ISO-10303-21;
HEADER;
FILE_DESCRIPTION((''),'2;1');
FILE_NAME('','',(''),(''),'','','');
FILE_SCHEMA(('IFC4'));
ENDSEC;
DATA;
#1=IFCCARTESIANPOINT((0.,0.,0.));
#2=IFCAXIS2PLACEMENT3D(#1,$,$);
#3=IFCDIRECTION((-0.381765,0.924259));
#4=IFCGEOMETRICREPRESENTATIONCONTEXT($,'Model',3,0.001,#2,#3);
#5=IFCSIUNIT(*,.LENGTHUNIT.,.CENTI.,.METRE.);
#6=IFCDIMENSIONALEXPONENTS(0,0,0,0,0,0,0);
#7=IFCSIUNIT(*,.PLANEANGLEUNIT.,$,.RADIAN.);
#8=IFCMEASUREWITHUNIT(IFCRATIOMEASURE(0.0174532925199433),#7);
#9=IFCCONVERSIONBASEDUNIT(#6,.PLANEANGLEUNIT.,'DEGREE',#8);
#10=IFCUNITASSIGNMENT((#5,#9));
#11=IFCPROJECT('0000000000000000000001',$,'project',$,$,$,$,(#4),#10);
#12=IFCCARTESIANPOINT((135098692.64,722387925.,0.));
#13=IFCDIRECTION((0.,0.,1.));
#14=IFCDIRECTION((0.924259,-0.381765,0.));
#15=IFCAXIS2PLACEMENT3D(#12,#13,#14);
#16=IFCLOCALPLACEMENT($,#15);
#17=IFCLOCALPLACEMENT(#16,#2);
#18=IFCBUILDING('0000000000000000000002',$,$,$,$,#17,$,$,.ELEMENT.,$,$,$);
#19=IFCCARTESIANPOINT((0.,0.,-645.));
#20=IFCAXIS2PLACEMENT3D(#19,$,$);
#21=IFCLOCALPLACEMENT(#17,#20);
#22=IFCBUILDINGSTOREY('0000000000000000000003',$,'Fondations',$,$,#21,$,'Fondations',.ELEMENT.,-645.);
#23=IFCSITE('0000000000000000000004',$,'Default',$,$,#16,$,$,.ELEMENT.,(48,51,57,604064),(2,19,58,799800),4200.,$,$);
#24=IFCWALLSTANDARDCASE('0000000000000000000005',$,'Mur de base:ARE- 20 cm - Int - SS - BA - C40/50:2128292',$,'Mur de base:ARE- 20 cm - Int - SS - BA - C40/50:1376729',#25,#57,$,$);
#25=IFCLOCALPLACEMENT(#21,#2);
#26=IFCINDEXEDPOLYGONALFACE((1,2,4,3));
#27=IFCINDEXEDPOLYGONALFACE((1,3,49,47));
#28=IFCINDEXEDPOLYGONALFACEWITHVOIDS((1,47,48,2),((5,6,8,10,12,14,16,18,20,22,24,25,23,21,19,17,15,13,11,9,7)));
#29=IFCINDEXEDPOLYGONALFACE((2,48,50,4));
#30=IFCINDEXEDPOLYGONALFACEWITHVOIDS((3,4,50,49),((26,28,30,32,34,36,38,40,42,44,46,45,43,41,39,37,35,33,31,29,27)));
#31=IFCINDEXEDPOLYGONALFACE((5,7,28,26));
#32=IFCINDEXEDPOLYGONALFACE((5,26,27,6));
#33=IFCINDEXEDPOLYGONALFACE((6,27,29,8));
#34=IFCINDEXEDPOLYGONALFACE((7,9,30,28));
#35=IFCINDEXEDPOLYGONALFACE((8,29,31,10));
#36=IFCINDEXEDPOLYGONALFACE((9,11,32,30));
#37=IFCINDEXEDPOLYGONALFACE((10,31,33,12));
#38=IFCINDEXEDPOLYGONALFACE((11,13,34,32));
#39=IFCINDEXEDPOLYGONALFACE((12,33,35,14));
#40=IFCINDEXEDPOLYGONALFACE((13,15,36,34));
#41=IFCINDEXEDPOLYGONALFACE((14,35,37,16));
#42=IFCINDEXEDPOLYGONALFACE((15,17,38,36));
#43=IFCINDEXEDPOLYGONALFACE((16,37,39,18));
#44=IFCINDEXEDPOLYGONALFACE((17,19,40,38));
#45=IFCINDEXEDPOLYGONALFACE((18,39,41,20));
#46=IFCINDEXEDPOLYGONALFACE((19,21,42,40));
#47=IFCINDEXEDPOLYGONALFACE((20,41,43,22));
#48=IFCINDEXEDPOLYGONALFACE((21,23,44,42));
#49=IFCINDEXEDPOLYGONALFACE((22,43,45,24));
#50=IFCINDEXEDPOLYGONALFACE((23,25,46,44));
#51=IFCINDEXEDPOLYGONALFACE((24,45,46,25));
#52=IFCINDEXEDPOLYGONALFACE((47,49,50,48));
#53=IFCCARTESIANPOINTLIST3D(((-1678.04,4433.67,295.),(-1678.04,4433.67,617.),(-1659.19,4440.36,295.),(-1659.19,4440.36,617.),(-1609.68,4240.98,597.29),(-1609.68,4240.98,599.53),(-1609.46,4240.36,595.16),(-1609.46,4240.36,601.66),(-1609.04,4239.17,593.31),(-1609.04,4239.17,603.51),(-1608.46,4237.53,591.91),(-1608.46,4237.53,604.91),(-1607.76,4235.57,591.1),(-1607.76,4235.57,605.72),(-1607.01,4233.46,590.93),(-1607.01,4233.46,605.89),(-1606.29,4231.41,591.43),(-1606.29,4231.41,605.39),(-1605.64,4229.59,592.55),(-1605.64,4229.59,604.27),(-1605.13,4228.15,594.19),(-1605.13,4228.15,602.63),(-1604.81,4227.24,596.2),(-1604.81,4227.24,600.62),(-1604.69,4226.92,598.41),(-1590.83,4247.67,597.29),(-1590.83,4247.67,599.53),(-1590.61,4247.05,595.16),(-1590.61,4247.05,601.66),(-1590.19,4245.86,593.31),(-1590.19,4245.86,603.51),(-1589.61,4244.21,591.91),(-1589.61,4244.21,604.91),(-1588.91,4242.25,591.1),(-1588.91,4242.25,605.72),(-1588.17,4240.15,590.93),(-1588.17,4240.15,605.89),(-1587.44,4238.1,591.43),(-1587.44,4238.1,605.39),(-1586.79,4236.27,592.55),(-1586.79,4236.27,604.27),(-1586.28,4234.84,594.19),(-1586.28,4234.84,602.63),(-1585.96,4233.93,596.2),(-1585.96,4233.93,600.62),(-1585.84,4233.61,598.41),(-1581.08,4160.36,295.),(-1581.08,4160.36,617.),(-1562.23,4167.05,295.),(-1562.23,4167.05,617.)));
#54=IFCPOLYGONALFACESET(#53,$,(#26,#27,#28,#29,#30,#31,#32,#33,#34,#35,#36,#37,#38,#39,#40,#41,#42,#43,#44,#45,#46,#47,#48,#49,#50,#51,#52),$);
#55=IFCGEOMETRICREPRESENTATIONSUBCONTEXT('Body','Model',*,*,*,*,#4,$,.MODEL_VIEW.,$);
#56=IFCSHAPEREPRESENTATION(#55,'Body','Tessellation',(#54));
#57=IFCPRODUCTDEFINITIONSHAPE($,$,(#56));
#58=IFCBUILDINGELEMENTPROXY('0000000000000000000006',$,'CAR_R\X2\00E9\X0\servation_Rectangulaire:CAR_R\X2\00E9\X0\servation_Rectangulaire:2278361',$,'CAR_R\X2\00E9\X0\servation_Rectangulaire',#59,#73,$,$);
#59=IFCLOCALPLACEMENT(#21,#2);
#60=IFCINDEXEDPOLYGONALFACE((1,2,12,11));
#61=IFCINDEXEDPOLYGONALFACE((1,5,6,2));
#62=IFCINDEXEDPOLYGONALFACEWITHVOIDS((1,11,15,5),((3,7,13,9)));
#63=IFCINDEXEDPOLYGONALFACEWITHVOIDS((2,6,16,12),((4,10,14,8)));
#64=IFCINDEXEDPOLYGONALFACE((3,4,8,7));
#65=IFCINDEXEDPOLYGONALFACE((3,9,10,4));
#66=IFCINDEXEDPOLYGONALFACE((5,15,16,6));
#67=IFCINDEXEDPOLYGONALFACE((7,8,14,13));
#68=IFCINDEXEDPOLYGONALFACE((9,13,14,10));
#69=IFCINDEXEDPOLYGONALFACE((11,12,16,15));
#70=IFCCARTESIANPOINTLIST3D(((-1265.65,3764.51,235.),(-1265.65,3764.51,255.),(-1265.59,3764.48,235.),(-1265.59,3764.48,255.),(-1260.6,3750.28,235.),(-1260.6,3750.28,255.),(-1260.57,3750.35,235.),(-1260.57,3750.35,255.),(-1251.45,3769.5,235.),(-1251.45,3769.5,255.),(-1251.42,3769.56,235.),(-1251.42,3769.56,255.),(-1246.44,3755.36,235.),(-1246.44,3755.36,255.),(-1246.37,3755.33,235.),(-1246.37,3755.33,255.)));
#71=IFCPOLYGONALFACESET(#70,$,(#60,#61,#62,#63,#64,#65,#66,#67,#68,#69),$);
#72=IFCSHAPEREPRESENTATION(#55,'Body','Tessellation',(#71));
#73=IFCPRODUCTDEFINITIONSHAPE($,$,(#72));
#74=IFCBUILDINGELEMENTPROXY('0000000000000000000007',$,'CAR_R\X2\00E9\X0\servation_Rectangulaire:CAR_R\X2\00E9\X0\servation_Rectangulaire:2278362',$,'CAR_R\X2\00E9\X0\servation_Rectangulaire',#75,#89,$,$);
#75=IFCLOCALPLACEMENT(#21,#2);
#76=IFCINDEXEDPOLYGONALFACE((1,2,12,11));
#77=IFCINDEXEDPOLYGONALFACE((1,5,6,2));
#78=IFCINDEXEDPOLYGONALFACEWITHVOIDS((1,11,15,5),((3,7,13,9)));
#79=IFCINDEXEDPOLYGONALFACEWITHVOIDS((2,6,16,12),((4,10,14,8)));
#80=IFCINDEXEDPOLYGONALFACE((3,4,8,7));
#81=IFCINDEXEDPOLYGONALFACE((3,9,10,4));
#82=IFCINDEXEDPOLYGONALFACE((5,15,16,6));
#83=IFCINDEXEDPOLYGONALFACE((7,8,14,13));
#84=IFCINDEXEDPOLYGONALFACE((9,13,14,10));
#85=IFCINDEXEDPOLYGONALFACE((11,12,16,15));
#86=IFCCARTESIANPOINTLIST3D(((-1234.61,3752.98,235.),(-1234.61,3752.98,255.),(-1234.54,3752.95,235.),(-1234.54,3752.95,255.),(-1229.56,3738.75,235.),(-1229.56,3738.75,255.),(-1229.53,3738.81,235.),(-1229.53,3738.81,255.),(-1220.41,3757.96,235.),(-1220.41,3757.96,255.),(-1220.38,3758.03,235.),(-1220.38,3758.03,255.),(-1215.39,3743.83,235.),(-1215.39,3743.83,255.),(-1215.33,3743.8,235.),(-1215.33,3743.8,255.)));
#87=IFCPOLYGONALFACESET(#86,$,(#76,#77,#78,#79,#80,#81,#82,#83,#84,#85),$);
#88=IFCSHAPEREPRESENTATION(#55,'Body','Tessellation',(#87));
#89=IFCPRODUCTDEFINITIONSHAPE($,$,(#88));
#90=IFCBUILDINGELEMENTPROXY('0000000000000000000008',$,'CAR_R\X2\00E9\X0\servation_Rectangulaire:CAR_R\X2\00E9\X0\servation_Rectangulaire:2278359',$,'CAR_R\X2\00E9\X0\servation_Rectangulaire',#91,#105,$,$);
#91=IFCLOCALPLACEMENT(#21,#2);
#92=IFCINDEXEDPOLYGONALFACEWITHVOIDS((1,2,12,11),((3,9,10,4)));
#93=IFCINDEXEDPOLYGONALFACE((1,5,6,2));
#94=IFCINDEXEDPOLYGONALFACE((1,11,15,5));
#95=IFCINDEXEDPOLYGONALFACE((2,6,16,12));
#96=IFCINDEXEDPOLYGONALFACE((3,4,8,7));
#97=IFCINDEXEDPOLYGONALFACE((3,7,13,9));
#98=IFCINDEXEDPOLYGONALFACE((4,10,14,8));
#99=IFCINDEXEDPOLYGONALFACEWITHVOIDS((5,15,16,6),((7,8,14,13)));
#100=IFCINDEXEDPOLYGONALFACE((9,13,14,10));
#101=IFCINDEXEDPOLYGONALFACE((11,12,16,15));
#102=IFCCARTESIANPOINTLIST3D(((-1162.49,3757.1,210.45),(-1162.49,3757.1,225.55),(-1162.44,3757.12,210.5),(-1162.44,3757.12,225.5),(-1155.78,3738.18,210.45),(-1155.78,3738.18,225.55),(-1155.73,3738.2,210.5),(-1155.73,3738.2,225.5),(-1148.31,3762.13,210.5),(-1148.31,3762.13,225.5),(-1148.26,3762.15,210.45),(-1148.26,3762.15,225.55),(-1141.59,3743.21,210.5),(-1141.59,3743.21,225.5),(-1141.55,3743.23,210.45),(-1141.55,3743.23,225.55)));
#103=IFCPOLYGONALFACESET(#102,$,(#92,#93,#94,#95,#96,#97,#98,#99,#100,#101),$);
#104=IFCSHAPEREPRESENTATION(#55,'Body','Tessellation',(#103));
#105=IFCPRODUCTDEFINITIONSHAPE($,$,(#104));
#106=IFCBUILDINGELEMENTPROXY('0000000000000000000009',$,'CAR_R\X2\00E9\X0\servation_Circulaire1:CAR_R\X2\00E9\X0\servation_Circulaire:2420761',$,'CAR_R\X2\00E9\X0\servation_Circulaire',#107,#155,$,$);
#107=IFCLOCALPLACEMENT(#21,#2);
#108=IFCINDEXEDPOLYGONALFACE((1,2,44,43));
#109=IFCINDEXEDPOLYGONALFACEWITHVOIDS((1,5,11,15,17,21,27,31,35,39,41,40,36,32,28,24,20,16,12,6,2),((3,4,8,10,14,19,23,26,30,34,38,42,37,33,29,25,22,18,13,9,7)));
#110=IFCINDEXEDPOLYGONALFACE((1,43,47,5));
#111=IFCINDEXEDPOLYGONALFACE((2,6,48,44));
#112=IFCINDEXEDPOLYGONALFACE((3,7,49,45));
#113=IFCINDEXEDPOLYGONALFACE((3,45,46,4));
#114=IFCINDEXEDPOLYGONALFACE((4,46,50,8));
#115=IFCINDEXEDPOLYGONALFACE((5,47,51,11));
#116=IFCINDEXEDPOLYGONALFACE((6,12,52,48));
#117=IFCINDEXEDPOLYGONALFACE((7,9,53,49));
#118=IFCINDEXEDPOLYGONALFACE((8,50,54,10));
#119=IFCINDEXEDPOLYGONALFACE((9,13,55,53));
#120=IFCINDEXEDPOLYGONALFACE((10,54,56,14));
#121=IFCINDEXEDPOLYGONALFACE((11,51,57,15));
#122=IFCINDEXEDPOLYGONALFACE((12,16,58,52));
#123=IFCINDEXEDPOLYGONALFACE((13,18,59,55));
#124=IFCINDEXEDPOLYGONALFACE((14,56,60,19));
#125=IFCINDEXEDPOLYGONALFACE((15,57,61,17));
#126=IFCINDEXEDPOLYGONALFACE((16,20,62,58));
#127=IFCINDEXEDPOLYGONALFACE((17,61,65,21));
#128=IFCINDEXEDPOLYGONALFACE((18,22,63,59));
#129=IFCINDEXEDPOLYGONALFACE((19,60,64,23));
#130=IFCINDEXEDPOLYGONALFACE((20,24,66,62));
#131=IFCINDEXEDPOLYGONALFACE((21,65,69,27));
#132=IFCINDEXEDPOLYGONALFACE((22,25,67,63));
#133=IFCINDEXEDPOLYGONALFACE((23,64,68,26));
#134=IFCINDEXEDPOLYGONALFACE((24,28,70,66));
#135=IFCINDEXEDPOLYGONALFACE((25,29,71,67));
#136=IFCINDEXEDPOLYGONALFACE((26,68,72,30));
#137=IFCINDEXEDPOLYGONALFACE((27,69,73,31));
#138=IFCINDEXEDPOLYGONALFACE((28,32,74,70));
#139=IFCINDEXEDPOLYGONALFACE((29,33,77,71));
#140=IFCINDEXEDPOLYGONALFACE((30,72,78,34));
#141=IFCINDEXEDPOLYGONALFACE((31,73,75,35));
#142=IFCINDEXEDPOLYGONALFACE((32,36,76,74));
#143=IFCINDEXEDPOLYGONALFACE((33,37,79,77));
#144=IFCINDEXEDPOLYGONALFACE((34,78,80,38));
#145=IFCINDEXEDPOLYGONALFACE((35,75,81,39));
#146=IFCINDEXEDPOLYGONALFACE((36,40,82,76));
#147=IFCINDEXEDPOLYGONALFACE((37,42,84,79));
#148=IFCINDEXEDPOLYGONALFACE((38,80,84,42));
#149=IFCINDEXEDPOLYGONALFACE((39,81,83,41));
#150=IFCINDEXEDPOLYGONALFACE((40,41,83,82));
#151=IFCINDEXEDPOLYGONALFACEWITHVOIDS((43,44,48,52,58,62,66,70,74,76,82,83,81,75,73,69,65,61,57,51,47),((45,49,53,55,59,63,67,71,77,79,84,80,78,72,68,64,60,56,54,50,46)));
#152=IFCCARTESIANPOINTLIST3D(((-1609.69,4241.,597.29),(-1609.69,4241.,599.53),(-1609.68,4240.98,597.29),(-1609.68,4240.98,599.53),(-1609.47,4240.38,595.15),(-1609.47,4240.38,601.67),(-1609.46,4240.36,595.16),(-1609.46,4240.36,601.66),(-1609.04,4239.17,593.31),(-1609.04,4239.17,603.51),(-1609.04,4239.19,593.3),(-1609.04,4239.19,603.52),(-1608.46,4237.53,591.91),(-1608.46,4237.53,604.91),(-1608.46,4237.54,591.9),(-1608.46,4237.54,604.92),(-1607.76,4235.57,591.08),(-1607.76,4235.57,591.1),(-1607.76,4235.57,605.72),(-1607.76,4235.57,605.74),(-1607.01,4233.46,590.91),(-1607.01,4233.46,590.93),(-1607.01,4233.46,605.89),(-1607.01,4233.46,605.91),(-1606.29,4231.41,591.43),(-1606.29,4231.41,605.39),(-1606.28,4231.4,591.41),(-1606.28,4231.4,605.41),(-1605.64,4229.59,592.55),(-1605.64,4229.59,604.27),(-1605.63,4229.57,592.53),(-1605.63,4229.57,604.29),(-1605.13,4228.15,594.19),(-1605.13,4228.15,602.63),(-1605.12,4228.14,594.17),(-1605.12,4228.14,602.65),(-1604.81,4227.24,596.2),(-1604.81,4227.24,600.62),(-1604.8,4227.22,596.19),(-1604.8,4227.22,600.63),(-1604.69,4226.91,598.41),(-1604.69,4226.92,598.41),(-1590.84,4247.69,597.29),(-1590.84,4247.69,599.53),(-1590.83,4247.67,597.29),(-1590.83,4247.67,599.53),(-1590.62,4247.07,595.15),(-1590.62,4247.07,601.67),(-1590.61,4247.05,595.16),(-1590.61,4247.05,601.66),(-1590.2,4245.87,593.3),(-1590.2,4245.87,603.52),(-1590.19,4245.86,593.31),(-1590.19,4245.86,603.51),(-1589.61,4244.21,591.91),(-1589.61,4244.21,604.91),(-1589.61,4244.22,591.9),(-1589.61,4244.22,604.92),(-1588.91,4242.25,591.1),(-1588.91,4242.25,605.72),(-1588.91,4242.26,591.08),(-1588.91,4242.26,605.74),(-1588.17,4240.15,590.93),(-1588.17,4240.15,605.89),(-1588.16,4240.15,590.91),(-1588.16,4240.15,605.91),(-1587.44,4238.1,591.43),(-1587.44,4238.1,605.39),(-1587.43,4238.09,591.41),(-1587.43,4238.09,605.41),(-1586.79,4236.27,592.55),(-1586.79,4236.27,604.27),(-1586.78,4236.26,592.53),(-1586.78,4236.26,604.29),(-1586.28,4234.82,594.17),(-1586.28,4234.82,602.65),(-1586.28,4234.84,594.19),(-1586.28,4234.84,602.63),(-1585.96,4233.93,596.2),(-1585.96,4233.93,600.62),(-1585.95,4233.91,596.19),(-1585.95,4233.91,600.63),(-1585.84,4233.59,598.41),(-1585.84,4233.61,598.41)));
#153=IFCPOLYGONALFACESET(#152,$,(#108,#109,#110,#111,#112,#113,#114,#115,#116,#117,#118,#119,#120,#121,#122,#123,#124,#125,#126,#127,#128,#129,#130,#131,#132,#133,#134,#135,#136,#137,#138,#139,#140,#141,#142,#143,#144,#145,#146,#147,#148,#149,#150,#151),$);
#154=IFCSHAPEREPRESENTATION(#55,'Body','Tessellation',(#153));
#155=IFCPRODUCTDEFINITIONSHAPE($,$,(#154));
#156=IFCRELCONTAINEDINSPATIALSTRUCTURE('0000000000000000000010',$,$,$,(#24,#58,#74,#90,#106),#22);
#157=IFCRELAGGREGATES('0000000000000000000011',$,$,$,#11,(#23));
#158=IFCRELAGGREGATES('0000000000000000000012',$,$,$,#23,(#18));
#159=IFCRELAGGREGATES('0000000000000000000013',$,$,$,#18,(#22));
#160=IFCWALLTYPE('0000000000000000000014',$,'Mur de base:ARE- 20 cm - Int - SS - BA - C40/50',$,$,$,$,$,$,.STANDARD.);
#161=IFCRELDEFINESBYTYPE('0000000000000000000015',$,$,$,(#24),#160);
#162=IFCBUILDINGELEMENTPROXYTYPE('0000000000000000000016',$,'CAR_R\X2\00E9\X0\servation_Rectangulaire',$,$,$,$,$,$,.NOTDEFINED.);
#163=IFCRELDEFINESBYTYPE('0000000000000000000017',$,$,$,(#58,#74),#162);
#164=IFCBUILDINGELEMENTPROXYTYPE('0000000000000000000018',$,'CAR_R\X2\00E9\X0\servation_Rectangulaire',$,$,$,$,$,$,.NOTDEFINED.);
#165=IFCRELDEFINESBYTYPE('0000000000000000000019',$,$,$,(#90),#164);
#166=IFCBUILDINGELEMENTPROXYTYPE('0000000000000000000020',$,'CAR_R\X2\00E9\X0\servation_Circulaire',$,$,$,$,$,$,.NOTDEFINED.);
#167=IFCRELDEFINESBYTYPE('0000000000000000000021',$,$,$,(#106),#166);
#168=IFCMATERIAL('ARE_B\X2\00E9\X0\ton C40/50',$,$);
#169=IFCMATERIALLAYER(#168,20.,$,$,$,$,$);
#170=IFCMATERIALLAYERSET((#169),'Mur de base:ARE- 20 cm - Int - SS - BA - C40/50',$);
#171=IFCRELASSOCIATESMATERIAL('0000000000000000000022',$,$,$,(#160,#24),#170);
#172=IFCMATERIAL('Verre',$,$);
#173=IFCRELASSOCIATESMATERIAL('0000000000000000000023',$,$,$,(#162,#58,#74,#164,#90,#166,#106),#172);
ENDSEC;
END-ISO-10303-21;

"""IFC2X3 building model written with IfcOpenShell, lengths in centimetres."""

from ifc_helpers import new_model, entity, si_unit, converted_unit, direction, frame, frame_2d, origin, place, context, subcontext, project, spatial, polyline, rectangle, circle, hollow_circle, outline, extrude, clip, bounded_halfspace, source, transform, mapped, material, layer, layer_set, layer_usage, type_object, type_shapes, element, save


model = new_model("IFC2X3")

# Units and contexts
model_context = context("Model", 3, precision=0.001, world=origin(), true_north=direction((-0.381765, 0.924259)))
body_context = subcontext(model_context, "Body", "Model", "MODEL_VIEW")
ifc_project = project(units=[si_unit("LENGTHUNIT", "METRE", prefix="CENTI"), converted_unit("PLANEANGLEUNIT", "DEGREE", entity("IfcRatioMeasure", 0.0174532925199433), si_unit("PLANEANGLEUNIT", "RADIAN"), dimensions=[0, 0, 0, 0, 0, 0, 0])], contexts=[model_context])

# Site, building, storey
site_placement = place(None, frame((135098692.64, 722387925.0, 0.0), z_axis=(0.0, 0.0, 1.0), x_axis=(0.924259, -0.381765, 0.0)))
site = spatial("IfcSite", under=ifc_project, at=site_placement, Name="Default", CompositionType="ELEMENT", RefLatitude=(48, 51, 57, 604064), RefLongitude=(2, 19, 58, 799800), RefElevation=4200.0)
building_placement = place(site_placement, origin())
building = spatial("IfcBuilding", under=site, at=building_placement, CompositionType="ELEMENT")
storey_placement = place(building_placement, frame((0.0, 0.0, -645.0)))
storey = spatial("IfcBuildingStorey", under=building, at=storey_placement, Name="Fondations", LongName="Fondations", CompositionType="ELEMENT", Elevation=-645.0)

# Shared definitions
ifc_material_1 = material(Name="ARE_Béton C40/50")

# Shared definitions
ifc_layer_1 = layer(ifc_material_1, 20.0)
ifc_layer_set_1 = layer_set([ifc_layer_1], Name="Mur de base:ARE- 20 cm - Int - SS - BA - C40/50")
wall_type_1 = type_object("IfcWallType", Name="Mur de base:ARE- 20 cm - Int - SS - BA - C40/50", PredefinedType="STANDARD", material=ifc_layer_set_1)

# Wall, opening
ifc_layer_usage_1 = layer_usage(ifc_layer_set_1, "AXIS2", "NEGATIVE", 10.0)
wall_1_placement = place(storey_placement, frame((-1571.66, 4163.71, 295.0), z_axis=(0.0, 0.0, 1.0), x_axis=(-0.334351, 0.942449, 0.0)))
wall_1 = element("IfcWallStandardCase", 1, at=wall_1_placement, inside=storey, type_object=wall_type_1, material=ifc_layer_usage_1, Name="Mur de base:ARE- 20 cm - Int - SS - BA - C40/50:2128292", ObjectType="Mur de base:ARE- 20 cm - Int - SS - BA - C40/50:1376729", context=body_context, shape_type="Clipping", body=[
    clip(extrude(rectangle(XDim=290.0, YDim=20.0, at=frame_2d((145.0, 0.0), x_axis=(-1.0, 0.0))), origin(), (0.0, 0.0, 1.0), 322.0), bounded_halfspace(frame((0.0, -10.0, 322.0), z_axis=(0.0, 0.0, -1.0), x_axis=(0.23358, -0.972338, 0.0)), True, frame((0.0, -10.0, 322.0)), polyline([(0.0, 0.0), (290.0, 0.0), (290.0, 20.0), (265.99, 20.0), (20.0, 20.0), (0.0, 20.0), (0.0, 0.0)]))),
])
opening_1_placement = place(wall_1_placement, origin())
element("IfcOpeningElement", 2, at=opening_1_placement, cuts=wall_1, ObjectType="Opening", context=body_context, shape_type="SweptSolid", body=[
    extrude(circle(Radius=7.5, at=frame_2d((0.0, 0.0), x_axis=(1.0, 0.0))), frame((78.13, -10.0, 303.41), z_axis=(0.0, 1.0, 0.0), x_axis=(-1.0, 0.0, 0.0)), (0.0, 0.0, 1.0), 20.0),
])

# Building element proxies
ifc_material_2 = material(Name="Verre")
building_element_proxy_type_1 = type_object("IfcBuildingElementProxyType", Name="CAR_Réservation_Rectangulaire", PredefinedType="NOTDEFINED", material=ifc_material_2)
shared_shape_1 = source(origin(), body_context, "Body", "SweptSolid", [
    extrude(outline(polyline([(-7.55, -7.55), (7.55, -7.55), (7.55, 7.55), (-7.55, 7.55), (-7.55, -7.55)]), holes=[polyline([(7.5, -7.5), (-7.5, -7.5), (-7.5, 7.5), (7.5, 7.5), (7.5, -7.5)])]), frame((0.0, 0.0, -20.0), z_axis=(0.0, 0.0, 1.0), x_axis=(-1.0, 0.0, 0.0)), (0.0, 0.0, 1.0), 20.0),
])
type_shapes(building_element_proxy_type_1, [shared_shape_1])
for number, where, z_axis, x_axis, name in (
    (3, (-1256.01, 3759.92, 235.0), (0.0, 0.0, -1.0), (0.942456, 0.334331, 0.0), "CAR_Réservation_Rectangulaire:CAR_Réservation_Rectangulaire:2278361"),
    (4, (-1224.97, 3748.39, 235.0), (0.0, 0.0, -1.0), (0.942456, 0.334331, 0.0), "CAR_Réservation_Rectangulaire:CAR_Réservation_Rectangulaire:2278362"),
):
    element("IfcBuildingElementProxy", number, at=place(storey_placement, frame(where, z_axis=z_axis, x_axis=x_axis)), inside=storey, type_object=building_element_proxy_type_1, material=ifc_material_2, Name=name, ObjectType="CAR_Réservation_Rectangulaire", context=body_context, shape_type="MappedRepresentation", body=[
        mapped(shared_shape_1, transform((0.0, 0.0, 0.0), scale=1.0)),
    ])
building_element_proxy_type_2 = type_object("IfcBuildingElementProxyType", Name="CAR_Réservation_Rectangulaire", PredefinedType="NOTDEFINED", material=ifc_material_2)
shared_shape_2 = source(origin(), body_context, "Body", "SweptSolid", [
    extrude(outline(polyline([(-7.55, -7.55), (7.55, -7.55), (7.55, 7.55), (-7.55, 7.55), (-7.55, -7.55)]), holes=[polyline([(7.5, -7.5), (-7.5, -7.5), (-7.5, 7.5), (7.5, 7.5), (7.5, -7.5)])]), frame((0.0, 0.0, -20.08), z_axis=(0.0, 0.0, 1.0), x_axis=(-1.0, 0.0, 0.0)), (0.0, 0.0, 1.0), 20.08),
])
type_shapes(building_element_proxy_type_2, [shared_shape_2])
proxy_1_placement = place(storey_placement, frame((-1155.37, 3759.62, 218.0), z_axis=(-0.334351, 0.942449, 0.0), x_axis=(-0.942449, -0.334351, 0.0)))
element("IfcBuildingElementProxy", 5, at=proxy_1_placement, inside=storey, type_object=building_element_proxy_type_2, material=ifc_material_2, Name="CAR_Réservation_Rectangulaire:CAR_Réservation_Rectangulaire:2278359", ObjectType="CAR_Réservation_Rectangulaire", context=body_context, shape_type="MappedRepresentation", body=[
    mapped(shared_shape_2, transform((0.0, 0.0, 0.0), scale=1.0)),
])
building_element_proxy_type_3 = type_object("IfcBuildingElementProxyType", Name="CAR_Réservation_Circulaire", PredefinedType="NOTDEFINED", material=ifc_material_2)
shared_shape_3 = source(origin(), body_context, "Body", "SweptSolid", [
    extrude(hollow_circle(Radius=7.52, WallThickness=0.02, at=frame_2d((0.0, 0.0), x_axis=(1.0, 0.0))), frame((0.0, 0.0, -20.0)), (0.0, 0.0, 1.0), 20.0),
])
type_shapes(building_element_proxy_type_3, [shared_shape_3])
proxy_2_placement = place(storey_placement, frame((-1607.2, 4233.99, 598.41), z_axis=(-0.942449, -0.334351, 0.0), x_axis=(0.334351, -0.942449, 0.0)))
element("IfcBuildingElementProxy", 6, at=proxy_2_placement, inside=storey, type_object=building_element_proxy_type_3, material=ifc_material_2, Name="CAR_Réservation_Circulaire1:CAR_Réservation_Circulaire:2420761", ObjectType="CAR_Réservation_Circulaire", context=body_context, shape_type="MappedRepresentation", body=[
    mapped(shared_shape_3, transform((0.0, 0.0, 0.0), scale=1.0)),
])

save(model, "model.ifc")
